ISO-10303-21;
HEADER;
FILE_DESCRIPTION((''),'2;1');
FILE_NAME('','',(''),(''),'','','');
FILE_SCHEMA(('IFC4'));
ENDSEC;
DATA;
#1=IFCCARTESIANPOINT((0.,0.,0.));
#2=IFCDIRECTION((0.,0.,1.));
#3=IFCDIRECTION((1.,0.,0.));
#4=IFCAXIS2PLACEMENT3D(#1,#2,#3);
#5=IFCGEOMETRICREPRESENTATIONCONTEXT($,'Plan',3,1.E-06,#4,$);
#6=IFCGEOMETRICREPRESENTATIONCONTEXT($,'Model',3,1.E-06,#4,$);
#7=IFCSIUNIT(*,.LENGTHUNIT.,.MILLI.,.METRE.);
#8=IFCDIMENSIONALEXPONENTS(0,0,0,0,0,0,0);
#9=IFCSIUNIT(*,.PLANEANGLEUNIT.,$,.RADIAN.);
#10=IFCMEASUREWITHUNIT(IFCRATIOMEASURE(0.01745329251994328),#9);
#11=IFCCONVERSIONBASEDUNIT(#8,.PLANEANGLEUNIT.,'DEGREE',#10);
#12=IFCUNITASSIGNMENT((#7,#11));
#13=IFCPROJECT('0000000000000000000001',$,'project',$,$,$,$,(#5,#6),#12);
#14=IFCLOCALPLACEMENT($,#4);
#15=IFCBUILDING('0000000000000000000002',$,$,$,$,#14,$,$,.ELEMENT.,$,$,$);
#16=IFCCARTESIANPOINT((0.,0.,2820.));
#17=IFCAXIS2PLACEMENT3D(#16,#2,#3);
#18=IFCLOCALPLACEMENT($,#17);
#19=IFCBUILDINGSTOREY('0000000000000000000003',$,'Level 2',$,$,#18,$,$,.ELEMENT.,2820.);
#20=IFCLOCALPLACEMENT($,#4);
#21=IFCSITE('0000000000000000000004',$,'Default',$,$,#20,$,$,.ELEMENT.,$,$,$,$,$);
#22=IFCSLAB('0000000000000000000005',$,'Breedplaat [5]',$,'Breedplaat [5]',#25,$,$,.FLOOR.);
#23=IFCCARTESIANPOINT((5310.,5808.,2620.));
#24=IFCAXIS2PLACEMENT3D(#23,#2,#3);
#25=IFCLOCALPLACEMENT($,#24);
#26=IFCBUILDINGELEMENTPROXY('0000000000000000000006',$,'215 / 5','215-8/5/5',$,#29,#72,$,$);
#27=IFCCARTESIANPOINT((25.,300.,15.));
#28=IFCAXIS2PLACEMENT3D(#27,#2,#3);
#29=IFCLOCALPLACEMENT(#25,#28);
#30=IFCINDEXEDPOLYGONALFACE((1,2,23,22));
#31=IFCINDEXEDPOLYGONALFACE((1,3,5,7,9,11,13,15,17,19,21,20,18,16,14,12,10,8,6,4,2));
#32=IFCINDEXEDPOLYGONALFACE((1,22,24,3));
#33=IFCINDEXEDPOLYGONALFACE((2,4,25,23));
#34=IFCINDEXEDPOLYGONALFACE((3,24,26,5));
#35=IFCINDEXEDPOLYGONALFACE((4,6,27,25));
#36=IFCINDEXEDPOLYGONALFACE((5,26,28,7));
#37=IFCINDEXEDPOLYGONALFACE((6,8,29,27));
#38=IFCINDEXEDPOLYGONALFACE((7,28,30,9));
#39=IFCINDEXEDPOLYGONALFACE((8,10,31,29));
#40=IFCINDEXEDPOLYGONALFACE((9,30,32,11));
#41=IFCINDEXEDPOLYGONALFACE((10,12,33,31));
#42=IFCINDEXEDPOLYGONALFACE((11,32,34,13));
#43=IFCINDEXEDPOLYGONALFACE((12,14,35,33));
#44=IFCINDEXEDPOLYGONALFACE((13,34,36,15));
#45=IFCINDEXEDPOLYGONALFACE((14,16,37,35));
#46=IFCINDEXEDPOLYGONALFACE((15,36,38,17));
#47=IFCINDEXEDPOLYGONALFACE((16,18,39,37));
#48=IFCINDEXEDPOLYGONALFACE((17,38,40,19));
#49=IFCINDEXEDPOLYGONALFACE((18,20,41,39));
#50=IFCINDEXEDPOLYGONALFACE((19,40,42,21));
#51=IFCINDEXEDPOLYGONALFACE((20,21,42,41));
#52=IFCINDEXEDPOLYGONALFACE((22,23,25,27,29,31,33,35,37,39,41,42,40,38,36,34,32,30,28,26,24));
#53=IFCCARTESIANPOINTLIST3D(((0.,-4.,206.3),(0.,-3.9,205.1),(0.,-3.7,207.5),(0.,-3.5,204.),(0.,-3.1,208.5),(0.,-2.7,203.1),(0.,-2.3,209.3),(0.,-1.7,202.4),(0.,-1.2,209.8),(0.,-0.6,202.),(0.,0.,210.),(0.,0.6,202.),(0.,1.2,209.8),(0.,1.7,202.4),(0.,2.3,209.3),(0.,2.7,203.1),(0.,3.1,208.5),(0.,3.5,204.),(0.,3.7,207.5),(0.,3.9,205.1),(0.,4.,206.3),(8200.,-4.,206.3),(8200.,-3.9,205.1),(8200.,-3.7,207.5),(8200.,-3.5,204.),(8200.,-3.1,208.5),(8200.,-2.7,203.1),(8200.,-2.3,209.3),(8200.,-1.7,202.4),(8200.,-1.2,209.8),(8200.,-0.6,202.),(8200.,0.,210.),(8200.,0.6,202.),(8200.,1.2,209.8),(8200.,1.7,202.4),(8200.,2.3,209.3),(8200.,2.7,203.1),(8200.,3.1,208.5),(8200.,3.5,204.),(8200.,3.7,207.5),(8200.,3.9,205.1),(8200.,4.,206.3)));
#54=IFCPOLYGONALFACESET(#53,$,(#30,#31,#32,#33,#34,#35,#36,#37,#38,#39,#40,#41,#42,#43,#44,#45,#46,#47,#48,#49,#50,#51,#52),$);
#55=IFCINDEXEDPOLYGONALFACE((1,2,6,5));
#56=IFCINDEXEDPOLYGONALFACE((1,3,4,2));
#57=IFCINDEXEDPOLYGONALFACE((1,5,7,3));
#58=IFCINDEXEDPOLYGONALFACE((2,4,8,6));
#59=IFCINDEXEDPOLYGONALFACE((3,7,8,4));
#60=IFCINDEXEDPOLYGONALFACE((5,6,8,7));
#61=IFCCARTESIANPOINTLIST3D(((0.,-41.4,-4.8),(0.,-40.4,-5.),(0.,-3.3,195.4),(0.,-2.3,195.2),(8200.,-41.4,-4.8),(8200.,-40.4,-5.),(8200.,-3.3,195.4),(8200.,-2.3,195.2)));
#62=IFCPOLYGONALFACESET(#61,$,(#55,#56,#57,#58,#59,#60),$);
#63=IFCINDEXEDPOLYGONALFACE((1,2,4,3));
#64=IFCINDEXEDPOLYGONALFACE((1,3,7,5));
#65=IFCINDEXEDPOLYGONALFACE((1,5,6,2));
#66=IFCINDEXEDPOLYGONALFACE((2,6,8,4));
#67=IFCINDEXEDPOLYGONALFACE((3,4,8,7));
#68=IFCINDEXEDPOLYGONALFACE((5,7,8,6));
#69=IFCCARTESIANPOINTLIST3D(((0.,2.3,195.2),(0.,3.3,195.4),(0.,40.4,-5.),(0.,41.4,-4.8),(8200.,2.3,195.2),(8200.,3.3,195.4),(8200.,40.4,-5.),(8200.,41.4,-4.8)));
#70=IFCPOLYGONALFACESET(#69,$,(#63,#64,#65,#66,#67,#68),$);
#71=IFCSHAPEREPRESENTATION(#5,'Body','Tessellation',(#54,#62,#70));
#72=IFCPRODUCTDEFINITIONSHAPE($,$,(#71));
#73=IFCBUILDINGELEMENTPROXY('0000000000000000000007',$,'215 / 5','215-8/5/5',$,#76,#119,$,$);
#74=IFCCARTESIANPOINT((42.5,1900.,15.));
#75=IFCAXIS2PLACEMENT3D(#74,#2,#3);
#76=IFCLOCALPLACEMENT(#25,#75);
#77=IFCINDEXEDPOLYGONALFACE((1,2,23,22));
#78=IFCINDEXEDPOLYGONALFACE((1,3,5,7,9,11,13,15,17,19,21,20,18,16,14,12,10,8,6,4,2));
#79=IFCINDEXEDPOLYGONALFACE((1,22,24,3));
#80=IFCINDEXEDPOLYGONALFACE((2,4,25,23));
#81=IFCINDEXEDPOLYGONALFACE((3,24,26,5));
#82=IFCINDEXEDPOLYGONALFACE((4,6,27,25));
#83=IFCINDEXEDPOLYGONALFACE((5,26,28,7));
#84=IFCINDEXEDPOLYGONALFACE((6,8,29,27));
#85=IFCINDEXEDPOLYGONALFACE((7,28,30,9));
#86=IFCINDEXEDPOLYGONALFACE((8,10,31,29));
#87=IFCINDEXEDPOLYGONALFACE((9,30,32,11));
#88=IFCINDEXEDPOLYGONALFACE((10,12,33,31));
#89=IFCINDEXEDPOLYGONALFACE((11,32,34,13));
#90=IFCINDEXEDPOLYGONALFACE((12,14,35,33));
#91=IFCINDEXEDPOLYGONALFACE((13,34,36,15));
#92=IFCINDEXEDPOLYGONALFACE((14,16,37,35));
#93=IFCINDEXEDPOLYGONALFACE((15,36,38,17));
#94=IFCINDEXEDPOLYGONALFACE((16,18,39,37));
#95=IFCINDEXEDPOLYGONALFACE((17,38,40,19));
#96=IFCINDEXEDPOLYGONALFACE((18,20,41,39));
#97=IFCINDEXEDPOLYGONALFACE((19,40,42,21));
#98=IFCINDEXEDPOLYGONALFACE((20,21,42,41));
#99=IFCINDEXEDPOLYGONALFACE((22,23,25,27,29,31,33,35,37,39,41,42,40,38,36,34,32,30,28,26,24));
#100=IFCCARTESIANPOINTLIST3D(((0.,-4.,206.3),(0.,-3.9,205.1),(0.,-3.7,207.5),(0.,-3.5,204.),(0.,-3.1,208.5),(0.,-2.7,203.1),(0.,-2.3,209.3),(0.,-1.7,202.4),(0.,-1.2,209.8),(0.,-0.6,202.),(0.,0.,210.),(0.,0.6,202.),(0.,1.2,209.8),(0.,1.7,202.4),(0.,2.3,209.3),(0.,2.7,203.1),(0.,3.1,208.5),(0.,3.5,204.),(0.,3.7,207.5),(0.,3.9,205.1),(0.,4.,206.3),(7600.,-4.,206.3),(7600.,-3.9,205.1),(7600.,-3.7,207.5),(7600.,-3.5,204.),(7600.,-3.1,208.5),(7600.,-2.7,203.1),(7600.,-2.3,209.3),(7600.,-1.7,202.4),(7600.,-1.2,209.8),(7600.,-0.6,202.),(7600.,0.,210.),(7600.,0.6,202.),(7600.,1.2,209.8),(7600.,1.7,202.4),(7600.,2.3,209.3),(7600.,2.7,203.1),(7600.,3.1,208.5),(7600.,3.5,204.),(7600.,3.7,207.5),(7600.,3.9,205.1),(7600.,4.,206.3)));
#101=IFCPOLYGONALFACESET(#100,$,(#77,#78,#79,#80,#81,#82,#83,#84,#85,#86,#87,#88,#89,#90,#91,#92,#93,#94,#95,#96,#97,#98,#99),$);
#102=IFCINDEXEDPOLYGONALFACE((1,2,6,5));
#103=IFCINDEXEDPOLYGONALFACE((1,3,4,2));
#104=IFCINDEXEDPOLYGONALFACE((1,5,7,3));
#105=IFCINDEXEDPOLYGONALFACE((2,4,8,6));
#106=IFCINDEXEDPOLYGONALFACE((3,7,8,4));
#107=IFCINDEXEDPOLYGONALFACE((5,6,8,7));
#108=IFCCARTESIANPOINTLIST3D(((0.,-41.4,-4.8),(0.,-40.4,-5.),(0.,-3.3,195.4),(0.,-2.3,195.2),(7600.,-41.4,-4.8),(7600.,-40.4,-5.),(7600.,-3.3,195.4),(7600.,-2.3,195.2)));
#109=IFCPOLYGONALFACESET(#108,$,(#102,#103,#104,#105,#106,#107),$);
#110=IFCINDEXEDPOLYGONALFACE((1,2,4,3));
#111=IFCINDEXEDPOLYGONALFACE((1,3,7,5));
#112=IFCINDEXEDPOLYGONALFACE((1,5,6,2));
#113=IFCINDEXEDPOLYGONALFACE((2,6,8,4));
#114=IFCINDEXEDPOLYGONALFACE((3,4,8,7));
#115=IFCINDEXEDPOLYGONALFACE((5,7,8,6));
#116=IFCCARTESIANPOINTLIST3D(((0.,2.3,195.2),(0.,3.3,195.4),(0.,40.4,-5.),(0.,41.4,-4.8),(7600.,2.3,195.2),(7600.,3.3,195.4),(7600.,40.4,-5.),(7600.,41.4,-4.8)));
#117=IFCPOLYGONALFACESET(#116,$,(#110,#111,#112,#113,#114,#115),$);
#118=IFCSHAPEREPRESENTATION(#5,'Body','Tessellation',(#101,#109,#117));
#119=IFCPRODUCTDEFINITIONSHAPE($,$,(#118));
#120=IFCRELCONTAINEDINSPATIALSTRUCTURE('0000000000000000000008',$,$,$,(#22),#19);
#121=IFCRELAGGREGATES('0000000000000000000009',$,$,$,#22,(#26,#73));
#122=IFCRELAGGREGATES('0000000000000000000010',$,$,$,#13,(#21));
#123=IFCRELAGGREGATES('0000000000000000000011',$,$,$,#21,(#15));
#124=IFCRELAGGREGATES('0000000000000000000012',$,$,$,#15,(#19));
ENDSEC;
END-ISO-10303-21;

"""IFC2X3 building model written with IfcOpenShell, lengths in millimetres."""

from ifc_helpers import new_model, entity, si_unit, converted_unit, frame, origin_with_axes, origin_2d_with_axis, place, context, project, spatial, rectangle, circle, extrude, element, aggregate, save


model = new_model("IFC2X3")

# Units and contexts
plan_context = context("Plan", 3, precision=1e-06, world=origin_with_axes())
model_context = context("Model", 3, precision=1e-06, world=origin_with_axes())
ifc_project = project(units=[si_unit("LENGTHUNIT", "METRE", prefix="MILLI"), converted_unit("PLANEANGLEUNIT", "DEGREE", entity("IfcRatioMeasure", 0.01745329251994328), si_unit("PLANEANGLEUNIT", "RADIAN"), dimensions=[0, 0, 0, 0, 0, 0, 0])], contexts=[plan_context, model_context])

# Site, building, storey
site_placement = place(None, origin_with_axes())
site = spatial("IfcSite", under=ifc_project, at=site_placement, Name="Default", CompositionType="ELEMENT")
building_placement = place(None, origin_with_axes())
building = spatial("IfcBuilding", under=site, at=building_placement, CompositionType="ELEMENT")
storey_placement = place(None, frame((0.0, 0.0, 2820.0), z_axis=(0.0, 0.0, 1.0), x_axis=(1.0, 0.0, 0.0)))
storey = spatial("IfcBuildingStorey", under=building, at=storey_placement, Name="Level 2", CompositionType="ELEMENT", Elevation=2820.0)

# Slab, building element proxies
slab_1_placement = place(None, frame((5310.0, 5808.0, 2620.0), z_axis=(0.0, 0.0, 1.0), x_axis=(1.0, 0.0, 0.0)))
slab_1 = element("IfcSlab", 1, at=slab_1_placement, inside=storey, Name="Breedplaat [5]", ObjectType="Breedplaat [5]", PredefinedType="FLOOR")
proxy_1_placement = place(slab_1_placement, frame((25.0, 300.0, 15.0), z_axis=(0.0, 0.0, 1.0), x_axis=(1.0, 0.0, 0.0)))
proxy_1 = element("IfcBuildingElementProxy", 2, at=proxy_1_placement, Name="215 / 5", Description="215-8/5/5", context=plan_context, shape_type="SweptSolid", body=[
    extrude(circle(Radius=4.0, at=origin_2d_with_axis()), frame((0.0, 0.0, 206.0), z_axis=(1.0, 0.0, 0.0), x_axis=(0.0, 0.0, 1.0)), (0.0, 0.0, 1.0), 8200.0),
    extrude(rectangle(XDim=203.8, YDim=1.0, at=origin_2d_with_axis()), frame((0.0, -21.9, 95.2), z_axis=(1.0, 0.0, 0.0), x_axis=(0.0, 0.187112, 0.982339)), (0.0, 0.0, 1.0), 8200.0),
    extrude(rectangle(XDim=203.8, YDim=1.0, at=origin_2d_with_axis()), frame((0.0, 21.9, 95.2), z_axis=(1.0, 0.0, 0.0), x_axis=(0.0, -0.187112, 0.982339)), (0.0, 0.0, 1.0), 8200.0),
])
proxy_2_placement = place(slab_1_placement, frame((42.5, 1900.0, 15.0), z_axis=(0.0, 0.0, 1.0), x_axis=(1.0, 0.0, 0.0)))
proxy_2 = element("IfcBuildingElementProxy", 3, at=proxy_2_placement, Name="215 / 5", Description="215-8/5/5", context=plan_context, shape_type="SweptSolid", body=[
    extrude(circle(Radius=4.0, at=origin_2d_with_axis()), frame((0.0, 0.0, 206.0), z_axis=(1.0, 0.0, 0.0), x_axis=(0.0, 0.0, 1.0)), (0.0, 0.0, 1.0), 7600.0),
    extrude(rectangle(XDim=203.8, YDim=1.0, at=origin_2d_with_axis()), frame((0.0, -21.9, 95.2), z_axis=(1.0, 0.0, 0.0), x_axis=(0.0, 0.187112, 0.982339)), (0.0, 0.0, 1.0), 7600.0),
    extrude(rectangle(XDim=203.8, YDim=1.0, at=origin_2d_with_axis()), frame((0.0, 21.9, 95.2), z_axis=(1.0, 0.0, 0.0), x_axis=(0.0, -0.187112, 0.982339)), (0.0, 0.0, 1.0), 7600.0),
])
aggregate(slab_1, [proxy_1, proxy_2])

save(model, "model.ifc")
